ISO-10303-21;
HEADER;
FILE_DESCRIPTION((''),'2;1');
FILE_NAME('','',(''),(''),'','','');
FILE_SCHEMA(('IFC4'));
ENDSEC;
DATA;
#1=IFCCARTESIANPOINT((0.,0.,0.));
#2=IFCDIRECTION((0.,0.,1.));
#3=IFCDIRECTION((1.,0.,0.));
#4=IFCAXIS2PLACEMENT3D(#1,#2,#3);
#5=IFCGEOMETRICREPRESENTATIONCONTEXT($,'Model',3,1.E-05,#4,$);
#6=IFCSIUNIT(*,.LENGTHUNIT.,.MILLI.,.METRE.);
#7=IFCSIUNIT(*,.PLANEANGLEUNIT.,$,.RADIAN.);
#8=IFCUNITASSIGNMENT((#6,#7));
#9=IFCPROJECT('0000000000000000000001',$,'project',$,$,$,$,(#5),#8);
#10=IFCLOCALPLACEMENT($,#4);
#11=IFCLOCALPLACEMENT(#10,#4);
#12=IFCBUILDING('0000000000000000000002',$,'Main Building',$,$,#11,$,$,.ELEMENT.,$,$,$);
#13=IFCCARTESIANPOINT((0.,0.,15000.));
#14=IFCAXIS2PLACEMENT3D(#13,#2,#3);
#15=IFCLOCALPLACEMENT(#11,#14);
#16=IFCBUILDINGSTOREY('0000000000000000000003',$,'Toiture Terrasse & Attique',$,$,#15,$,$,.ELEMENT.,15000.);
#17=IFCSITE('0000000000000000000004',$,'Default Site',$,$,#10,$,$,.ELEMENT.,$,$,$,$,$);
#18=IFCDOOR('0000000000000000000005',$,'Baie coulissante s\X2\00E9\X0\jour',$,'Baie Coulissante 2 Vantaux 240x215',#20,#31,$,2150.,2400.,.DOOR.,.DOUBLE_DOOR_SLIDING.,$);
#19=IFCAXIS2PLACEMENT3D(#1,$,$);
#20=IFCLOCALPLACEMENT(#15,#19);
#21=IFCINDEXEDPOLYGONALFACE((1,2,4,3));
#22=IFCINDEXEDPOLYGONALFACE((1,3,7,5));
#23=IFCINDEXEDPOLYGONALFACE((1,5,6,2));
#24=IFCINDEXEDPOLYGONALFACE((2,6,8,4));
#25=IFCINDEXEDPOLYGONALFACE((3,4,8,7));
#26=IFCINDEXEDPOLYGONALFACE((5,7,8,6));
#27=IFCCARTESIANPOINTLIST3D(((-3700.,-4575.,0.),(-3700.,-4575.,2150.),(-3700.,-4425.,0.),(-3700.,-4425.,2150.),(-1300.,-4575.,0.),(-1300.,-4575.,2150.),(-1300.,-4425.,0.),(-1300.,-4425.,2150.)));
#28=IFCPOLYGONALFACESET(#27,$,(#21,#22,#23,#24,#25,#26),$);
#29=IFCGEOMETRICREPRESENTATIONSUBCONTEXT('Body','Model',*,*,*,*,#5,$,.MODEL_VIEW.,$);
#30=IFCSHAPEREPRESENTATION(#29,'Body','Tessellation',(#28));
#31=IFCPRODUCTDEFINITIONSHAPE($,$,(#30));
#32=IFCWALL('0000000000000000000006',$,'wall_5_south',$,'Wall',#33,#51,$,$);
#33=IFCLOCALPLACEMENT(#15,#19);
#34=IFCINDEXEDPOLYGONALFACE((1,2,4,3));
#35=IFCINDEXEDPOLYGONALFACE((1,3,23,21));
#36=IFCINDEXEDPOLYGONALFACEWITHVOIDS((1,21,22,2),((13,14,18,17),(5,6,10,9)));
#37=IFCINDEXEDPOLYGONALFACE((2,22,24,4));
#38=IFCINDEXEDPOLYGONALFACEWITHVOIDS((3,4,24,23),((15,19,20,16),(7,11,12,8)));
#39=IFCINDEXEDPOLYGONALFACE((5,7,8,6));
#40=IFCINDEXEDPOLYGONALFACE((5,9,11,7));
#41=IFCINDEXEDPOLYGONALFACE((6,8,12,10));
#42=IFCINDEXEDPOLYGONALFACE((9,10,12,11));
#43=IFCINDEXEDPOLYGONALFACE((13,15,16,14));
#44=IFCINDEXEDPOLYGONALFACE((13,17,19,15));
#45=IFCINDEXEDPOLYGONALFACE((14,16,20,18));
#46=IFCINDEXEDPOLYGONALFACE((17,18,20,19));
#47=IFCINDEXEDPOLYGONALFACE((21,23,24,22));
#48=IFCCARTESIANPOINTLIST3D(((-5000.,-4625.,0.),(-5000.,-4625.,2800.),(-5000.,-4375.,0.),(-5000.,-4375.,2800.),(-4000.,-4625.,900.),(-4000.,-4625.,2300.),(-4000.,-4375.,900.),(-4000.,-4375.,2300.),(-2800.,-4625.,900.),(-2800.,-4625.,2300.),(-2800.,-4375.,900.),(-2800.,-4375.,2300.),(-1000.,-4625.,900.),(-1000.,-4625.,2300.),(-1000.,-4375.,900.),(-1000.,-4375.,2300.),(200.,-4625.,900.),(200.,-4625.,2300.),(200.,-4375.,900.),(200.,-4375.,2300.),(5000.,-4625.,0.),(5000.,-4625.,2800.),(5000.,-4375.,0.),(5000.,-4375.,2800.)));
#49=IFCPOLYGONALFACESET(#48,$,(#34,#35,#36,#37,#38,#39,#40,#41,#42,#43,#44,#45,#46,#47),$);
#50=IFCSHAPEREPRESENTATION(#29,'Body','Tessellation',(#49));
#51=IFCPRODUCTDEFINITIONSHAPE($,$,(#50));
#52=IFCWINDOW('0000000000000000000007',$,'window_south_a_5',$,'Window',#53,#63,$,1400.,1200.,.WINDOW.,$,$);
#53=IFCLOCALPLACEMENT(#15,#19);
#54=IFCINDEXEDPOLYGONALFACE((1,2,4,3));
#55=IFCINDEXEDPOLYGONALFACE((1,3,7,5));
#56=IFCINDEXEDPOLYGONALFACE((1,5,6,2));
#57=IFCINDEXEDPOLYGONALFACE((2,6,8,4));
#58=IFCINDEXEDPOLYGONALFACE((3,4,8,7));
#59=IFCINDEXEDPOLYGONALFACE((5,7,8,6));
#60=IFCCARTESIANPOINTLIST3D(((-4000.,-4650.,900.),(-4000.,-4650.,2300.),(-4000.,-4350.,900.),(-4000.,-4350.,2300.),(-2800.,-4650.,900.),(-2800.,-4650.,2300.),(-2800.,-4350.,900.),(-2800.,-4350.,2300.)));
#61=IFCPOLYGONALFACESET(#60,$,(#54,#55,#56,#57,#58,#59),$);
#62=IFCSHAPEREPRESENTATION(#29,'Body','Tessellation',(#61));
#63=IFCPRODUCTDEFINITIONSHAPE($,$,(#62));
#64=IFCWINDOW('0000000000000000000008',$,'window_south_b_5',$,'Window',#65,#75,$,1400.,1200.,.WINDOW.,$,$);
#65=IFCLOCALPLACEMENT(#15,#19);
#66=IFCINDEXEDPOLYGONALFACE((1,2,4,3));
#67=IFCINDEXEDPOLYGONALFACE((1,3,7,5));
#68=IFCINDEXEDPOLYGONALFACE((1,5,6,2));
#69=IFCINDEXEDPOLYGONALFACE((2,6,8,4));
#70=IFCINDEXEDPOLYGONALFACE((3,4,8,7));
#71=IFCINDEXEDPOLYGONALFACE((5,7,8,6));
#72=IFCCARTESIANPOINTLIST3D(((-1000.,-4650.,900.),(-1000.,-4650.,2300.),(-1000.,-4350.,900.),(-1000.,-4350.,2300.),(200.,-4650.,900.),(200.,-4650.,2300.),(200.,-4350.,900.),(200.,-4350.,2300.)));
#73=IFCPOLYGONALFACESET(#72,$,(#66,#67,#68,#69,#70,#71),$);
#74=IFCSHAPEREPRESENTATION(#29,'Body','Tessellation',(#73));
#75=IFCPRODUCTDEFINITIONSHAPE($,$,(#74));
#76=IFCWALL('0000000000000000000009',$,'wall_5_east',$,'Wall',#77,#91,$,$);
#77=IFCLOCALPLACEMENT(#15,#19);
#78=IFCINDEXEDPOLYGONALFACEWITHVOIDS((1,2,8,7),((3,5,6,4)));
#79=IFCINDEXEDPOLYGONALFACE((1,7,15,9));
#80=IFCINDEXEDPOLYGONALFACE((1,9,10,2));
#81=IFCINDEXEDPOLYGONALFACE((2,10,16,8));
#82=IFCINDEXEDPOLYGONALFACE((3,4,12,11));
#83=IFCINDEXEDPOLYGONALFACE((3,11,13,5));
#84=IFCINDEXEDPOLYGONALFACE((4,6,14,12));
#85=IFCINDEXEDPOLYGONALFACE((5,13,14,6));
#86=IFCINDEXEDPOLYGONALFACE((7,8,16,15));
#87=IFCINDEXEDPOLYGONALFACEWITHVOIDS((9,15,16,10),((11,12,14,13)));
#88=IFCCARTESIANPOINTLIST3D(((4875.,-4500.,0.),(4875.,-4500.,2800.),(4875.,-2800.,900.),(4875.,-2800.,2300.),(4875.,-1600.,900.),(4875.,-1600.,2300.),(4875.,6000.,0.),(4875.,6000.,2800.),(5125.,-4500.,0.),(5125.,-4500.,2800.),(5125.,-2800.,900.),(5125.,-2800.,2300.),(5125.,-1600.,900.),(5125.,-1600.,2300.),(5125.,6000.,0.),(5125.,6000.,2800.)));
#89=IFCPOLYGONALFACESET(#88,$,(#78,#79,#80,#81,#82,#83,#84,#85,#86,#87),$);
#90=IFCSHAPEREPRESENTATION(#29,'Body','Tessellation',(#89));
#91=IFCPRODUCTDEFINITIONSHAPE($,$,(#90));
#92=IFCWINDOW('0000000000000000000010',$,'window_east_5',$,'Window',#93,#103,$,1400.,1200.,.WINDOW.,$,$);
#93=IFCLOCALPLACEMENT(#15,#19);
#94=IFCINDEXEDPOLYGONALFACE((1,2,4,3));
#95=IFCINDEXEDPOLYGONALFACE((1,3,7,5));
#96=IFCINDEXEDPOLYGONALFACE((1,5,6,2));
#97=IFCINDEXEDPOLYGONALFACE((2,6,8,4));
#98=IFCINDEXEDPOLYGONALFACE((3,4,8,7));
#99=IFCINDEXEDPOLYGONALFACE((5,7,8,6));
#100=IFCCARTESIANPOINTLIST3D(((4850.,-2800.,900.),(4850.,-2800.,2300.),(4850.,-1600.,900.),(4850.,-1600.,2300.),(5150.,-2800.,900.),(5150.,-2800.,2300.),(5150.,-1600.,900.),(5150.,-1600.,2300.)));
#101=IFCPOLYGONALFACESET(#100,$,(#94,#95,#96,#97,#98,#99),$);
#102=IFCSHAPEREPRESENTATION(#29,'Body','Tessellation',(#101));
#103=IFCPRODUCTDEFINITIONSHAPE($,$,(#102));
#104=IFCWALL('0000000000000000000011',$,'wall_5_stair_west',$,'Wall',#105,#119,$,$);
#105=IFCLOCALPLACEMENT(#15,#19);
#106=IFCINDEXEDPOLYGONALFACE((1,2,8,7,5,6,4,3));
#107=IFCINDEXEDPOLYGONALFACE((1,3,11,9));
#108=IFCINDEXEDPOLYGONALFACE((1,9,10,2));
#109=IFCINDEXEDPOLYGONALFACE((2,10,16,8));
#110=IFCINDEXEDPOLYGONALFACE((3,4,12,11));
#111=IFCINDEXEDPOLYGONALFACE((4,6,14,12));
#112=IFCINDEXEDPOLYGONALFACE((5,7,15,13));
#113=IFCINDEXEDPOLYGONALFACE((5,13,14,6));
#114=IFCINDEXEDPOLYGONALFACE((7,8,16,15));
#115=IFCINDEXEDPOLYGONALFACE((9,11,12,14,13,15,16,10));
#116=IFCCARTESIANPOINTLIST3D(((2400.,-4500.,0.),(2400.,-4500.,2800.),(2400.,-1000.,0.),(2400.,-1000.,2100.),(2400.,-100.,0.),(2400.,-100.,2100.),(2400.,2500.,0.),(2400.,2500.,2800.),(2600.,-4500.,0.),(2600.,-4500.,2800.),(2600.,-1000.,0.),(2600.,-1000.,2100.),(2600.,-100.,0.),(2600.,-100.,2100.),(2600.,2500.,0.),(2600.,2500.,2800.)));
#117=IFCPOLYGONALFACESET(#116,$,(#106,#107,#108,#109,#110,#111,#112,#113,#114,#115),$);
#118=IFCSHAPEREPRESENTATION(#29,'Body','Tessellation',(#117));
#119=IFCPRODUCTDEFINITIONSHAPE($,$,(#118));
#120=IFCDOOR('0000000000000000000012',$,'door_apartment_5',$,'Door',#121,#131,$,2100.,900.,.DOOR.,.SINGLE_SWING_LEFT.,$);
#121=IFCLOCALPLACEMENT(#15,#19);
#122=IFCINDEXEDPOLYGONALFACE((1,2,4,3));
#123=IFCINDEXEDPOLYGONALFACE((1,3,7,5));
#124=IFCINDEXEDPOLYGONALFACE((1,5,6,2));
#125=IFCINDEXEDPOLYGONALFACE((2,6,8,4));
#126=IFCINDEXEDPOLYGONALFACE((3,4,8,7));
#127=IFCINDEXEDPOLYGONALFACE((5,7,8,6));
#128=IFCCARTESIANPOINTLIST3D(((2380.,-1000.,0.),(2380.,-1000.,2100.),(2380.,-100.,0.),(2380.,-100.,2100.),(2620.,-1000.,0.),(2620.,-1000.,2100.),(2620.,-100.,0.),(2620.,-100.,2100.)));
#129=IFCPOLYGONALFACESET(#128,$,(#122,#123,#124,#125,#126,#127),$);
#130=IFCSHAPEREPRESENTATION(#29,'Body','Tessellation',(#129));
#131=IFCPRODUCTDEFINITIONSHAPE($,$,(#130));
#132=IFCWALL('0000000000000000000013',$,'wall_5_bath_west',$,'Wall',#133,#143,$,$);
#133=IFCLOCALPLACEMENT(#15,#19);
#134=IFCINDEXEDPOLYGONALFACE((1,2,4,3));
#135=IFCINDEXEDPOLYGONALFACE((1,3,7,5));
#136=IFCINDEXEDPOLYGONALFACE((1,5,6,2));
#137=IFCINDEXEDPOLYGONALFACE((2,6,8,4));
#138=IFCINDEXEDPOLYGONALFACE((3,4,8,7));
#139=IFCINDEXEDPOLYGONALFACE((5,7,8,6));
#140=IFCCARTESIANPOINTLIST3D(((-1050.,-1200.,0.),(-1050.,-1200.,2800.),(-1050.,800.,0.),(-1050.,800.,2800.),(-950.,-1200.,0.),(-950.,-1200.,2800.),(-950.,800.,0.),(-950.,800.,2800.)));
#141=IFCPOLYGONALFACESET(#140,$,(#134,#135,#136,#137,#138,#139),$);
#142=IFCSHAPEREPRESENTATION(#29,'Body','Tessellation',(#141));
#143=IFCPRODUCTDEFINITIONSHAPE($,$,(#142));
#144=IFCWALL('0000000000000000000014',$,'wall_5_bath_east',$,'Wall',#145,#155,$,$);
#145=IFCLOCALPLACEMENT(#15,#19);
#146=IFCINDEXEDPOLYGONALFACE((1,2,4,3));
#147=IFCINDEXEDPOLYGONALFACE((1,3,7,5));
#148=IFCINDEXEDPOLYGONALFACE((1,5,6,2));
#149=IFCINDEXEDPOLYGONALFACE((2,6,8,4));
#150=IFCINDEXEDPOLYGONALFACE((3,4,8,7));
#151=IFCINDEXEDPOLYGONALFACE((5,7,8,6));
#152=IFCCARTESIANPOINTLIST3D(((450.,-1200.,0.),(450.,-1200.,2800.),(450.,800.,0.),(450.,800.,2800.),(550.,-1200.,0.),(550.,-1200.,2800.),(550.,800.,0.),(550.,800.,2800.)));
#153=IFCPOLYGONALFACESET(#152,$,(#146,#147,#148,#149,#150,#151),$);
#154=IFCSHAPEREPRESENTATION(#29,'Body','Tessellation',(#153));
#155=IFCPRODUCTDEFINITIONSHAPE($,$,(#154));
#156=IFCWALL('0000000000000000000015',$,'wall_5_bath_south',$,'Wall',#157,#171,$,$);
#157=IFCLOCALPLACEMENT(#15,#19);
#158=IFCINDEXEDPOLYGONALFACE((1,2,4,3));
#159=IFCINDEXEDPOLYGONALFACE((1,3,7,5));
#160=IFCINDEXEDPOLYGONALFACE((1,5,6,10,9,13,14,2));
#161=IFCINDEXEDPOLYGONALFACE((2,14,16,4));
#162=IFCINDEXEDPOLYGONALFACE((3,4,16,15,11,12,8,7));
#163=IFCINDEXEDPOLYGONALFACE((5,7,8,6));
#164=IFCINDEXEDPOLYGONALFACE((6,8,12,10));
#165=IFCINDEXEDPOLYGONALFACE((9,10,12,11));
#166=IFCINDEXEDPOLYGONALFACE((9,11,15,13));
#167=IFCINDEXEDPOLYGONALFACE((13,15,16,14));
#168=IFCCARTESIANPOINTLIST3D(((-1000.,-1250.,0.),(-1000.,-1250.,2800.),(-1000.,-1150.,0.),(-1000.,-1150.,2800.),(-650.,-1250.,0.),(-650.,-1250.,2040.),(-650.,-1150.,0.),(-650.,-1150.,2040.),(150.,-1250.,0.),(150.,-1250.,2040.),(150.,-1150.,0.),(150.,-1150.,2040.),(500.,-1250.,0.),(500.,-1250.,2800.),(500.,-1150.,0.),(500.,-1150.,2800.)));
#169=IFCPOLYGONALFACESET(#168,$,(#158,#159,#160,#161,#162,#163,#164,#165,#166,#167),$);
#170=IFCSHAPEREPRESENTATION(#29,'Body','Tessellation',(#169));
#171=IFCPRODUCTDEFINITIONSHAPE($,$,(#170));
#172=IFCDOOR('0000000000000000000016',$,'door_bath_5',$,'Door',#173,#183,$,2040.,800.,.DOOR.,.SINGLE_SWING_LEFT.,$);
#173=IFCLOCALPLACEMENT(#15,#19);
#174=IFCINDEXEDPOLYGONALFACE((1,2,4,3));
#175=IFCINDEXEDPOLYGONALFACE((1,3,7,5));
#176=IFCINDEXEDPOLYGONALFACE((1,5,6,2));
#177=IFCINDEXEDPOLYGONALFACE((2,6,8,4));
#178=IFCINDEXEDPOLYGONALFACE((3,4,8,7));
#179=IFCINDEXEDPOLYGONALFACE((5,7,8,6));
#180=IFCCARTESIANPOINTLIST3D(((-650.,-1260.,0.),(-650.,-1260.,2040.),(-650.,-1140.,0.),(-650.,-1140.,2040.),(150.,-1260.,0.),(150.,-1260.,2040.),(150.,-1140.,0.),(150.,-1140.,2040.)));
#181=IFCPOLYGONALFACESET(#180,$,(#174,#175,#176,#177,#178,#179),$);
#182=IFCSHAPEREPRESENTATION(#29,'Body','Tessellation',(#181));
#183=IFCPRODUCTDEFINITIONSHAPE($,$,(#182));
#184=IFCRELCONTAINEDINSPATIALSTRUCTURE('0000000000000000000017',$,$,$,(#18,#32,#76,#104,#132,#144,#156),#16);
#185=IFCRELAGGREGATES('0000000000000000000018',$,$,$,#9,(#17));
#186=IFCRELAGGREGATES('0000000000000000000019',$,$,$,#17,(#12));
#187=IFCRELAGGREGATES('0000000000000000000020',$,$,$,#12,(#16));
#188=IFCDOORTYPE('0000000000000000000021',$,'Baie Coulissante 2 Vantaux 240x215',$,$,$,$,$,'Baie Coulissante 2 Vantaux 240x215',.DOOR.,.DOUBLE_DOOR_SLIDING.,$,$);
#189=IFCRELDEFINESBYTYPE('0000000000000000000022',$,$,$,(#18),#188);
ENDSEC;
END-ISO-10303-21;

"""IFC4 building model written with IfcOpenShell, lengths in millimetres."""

from ifc_helpers import new_model, si_unit, frame, origin_with_axes, place, context, subcontext, project, spatial, polyline, outline, extrude, type_object, element, fill, save


model = new_model("IFC4")

# Units and contexts
model_context = context("Model", 3, precision=1e-05, world=origin_with_axes())
body_context = subcontext(model_context, "Body", "Model", "MODEL_VIEW")
ifc_project = project(units=[si_unit("LENGTHUNIT", "METRE", prefix="MILLI"), si_unit("PLANEANGLEUNIT", "RADIAN")], contexts=[model_context])

# Site, building, storey
site_placement = place(None, origin_with_axes())
site = spatial("IfcSite", under=ifc_project, at=site_placement, Name="Default Site", CompositionType="ELEMENT")
building_placement = place(site_placement, origin_with_axes())
building = spatial("IfcBuilding", under=site, at=building_placement, Name="Main Building", CompositionType="ELEMENT")
storey_placement = place(building_placement, frame((0.0, 0.0, 15000.0), z_axis=(0.0, 0.0, 1.0), x_axis=(1.0, 0.0, 0.0)))
storey = spatial("IfcBuildingStorey", under=building, at=storey_placement, Name="Toiture Terrasse & Attique", CompositionType="ELEMENT", Elevation=15000.0)

# Door
door_type = type_object("IfcDoorType", Name="Baie Coulissante 2 Vantaux 240x215", ElementType="Baie Coulissante 2 Vantaux 240x215", OperationType="DOUBLE_DOOR_SLIDING", PredefinedType="DOOR")
door_1_placement = place(storey_placement, frame((-2500.0, -4500.0, 0.0), z_axis=(0.0, 0.0, 1.0), x_axis=(1.0, 0.0, 0.0)))
element("IfcDoor", 1, at=door_1_placement, inside=storey, type_object=door_type, Name="Baie coulissante séjour", ObjectType="Baie Coulissante 2 Vantaux 240x215", OperationType="DOUBLE_DOOR_SLIDING", OverallHeight=2150.0, OverallWidth=2400.0, PredefinedType="DOOR", context=body_context, shape_type="SweptSolid", body=[
    extrude(outline(polyline([(-1200.0, -75.0), (1200.0, -75.0), (1200.0, 75.0), (-1200.0, 75.0), (-1200.0, -75.0)])), origin_with_axes(), (0.0, 0.0, 1.0), 2150.0),
])

# Wall, openings, windows
wall_1_placement = place(storey_placement, frame((-5000.0, -4500.0, 0.0), z_axis=(0.0, 0.0, 1.0), x_axis=(1.0, 0.0, 0.0)))
wall_1 = element("IfcWall", 2, at=wall_1_placement, inside=storey, Name="wall_5_south", ObjectType="Wall", context=body_context, shape_type="SweptSolid", body=[
    extrude(outline(polyline([(0.0, -125.0), (10000.0, -125.0), (10000.0, 125.0), (0.0, 125.0), (0.0, -125.0)])), origin_with_axes(), (0.0, 0.0, 1.0), 2800.0),
])
placement_1 = place(wall_1_placement, frame((1000.0, 0.0, 900.0), z_axis=(0.0, 0.0, 1.0), x_axis=(1.0, 0.0, 0.0)))
opening_1 = element("IfcOpeningElement", 3, at=placement_1, cuts=wall_1, PredefinedType="OPENING", context=body_context, shape_type="SweptSolid", body=[
    extrude(outline(polyline([(0.0, -150.0), (1200.0, -150.0), (1200.0, 150.0), (0.0, 150.0), (0.0, -150.0)])), origin_with_axes(), (0.0, 0.0, 1.0), 1400.0),
])
placement_2 = place(wall_1_placement, frame((4000.0, 0.0, 900.0), z_axis=(0.0, 0.0, 1.0), x_axis=(1.0, 0.0, 0.0)))
opening_2 = element("IfcOpeningElement", 4, at=placement_2, cuts=wall_1, PredefinedType="OPENING", context=body_context, shape_type="SweptSolid", body=[
    extrude(outline(polyline([(0.0, -150.0), (1200.0, -150.0), (1200.0, 150.0), (0.0, 150.0), (0.0, -150.0)])), origin_with_axes(), (0.0, 0.0, 1.0), 1400.0),
])
window_1 = element("IfcWindow", 5, at=placement_1, Name="window_south_a_5", ObjectType="Window", OverallHeight=1400.0, OverallWidth=1200.0, PredefinedType="WINDOW", context=body_context, shape_type="SweptSolid", body=[
    extrude(outline(polyline([(0.0, -150.0), (1200.0, -150.0), (1200.0, 150.0), (0.0, 150.0), (0.0, -150.0)])), origin_with_axes(), (0.0, 0.0, 1.0), 1400.0),
])
fill(opening_1, window_1)
window_2 = element("IfcWindow", 6, at=placement_2, Name="window_south_b_5", ObjectType="Window", OverallHeight=1400.0, OverallWidth=1200.0, PredefinedType="WINDOW", context=body_context, shape_type="SweptSolid", body=[
    extrude(outline(polyline([(0.0, -150.0), (1200.0, -150.0), (1200.0, 150.0), (0.0, 150.0), (0.0, -150.0)])), origin_with_axes(), (0.0, 0.0, 1.0), 1400.0),
])
fill(opening_2, window_2)

# Wall, opening, window
wall_2_placement = place(storey_placement, frame((5000.0, -4500.0, 0.0), z_axis=(0.0, 0.0, 1.0), x_axis=(0.0, 1.0, 0.0)))
wall_2 = element("IfcWall", 7, at=wall_2_placement, inside=storey, Name="wall_5_east", ObjectType="Wall", context=body_context, shape_type="SweptSolid", body=[
    extrude(outline(polyline([(0.0, -125.0), (10500.0, -125.0), (10500.0, 125.0), (0.0, 125.0), (0.0, -125.0)])), origin_with_axes(), (0.0, 0.0, 1.0), 2800.0),
])
placement_3 = place(wall_2_placement, frame((1700.0, 0.0, 900.0), z_axis=(0.0, 0.0, 1.0), x_axis=(1.0, 0.0, 0.0)))
opening_3 = element("IfcOpeningElement", 8, at=placement_3, cuts=wall_2, PredefinedType="OPENING", context=body_context, shape_type="SweptSolid", body=[
    extrude(outline(polyline([(0.0, -150.0), (1200.0, -150.0), (1200.0, 150.0), (0.0, 150.0), (0.0, -150.0)])), origin_with_axes(), (0.0, 0.0, 1.0), 1400.0),
])
window_3 = element("IfcWindow", 9, at=placement_3, Name="window_east_5", ObjectType="Window", OverallHeight=1400.0, OverallWidth=1200.0, PredefinedType="WINDOW", context=body_context, shape_type="SweptSolid", body=[
    extrude(outline(polyline([(0.0, -150.0), (1200.0, -150.0), (1200.0, 150.0), (0.0, 150.0), (0.0, -150.0)])), origin_with_axes(), (0.0, 0.0, 1.0), 1400.0),
])
fill(opening_3, window_3)

# Wall, opening, door
wall_3_placement = place(storey_placement, frame((2500.0, -4500.0, 0.0), z_axis=(0.0, 0.0, 1.0), x_axis=(0.0, 1.0, 0.0)))
wall_3 = element("IfcWall", 10, at=wall_3_placement, inside=storey, Name="wall_5_stair_west", ObjectType="Wall", context=body_context, shape_type="SweptSolid", body=[
    extrude(outline(polyline([(0.0, -100.0), (7000.0, -100.0), (7000.0, 100.0), (0.0, 100.0), (0.0, -100.0)])), origin_with_axes(), (0.0, 0.0, 1.0), 2800.0),
])
placement_4 = place(wall_3_placement, frame((3500.0, 0.0, 0.0), z_axis=(0.0, 0.0, 1.0), x_axis=(1.0, 0.0, 0.0)))
opening_4 = element("IfcOpeningElement", 11, at=placement_4, cuts=wall_3, PredefinedType="OPENING", context=body_context, shape_type="SweptSolid", body=[
    extrude(outline(polyline([(0.0, -120.0), (900.0, -120.0), (900.0, 120.0), (0.0, 120.0), (0.0, -120.0)])), origin_with_axes(), (0.0, 0.0, 1.0), 2100.0),
])
door_2 = element("IfcDoor", 12, at=placement_4, Name="door_apartment_5", ObjectType="Door", OperationType="SINGLE_SWING_LEFT", OverallHeight=2100.0, OverallWidth=900.0, PredefinedType="DOOR", context=body_context, shape_type="SweptSolid", body=[
    extrude(outline(polyline([(0.0, -120.0), (900.0, -120.0), (900.0, 120.0), (0.0, 120.0), (0.0, -120.0)])), origin_with_axes(), (0.0, 0.0, 1.0), 2100.0),
])
fill(opening_4, door_2)

# Walls
for number, where, z_axis, x_axis, name in (
    (13, (-1000.0, -1200.0, 0.0), (0.0, 0.0, 1.0), (0.0, 1.0, 0.0), "wall_5_bath_west"),
    (14, (500.0, -1200.0, 0.0), (0.0, 0.0, 1.0), (0.0, 1.0, 0.0), "wall_5_bath_east"),
):
    element("IfcWall", number, at=place(storey_placement, frame(where, z_axis=z_axis, x_axis=x_axis)), inside=storey, Name=name, ObjectType="Wall", context=body_context, shape_type="SweptSolid", body=[
        extrude(outline(polyline([(0.0, -50.0), (2000.0, -50.0), (2000.0, 50.0), (0.0, 50.0), (0.0, -50.0)])), origin_with_axes(), (0.0, 0.0, 1.0), 2800.0),
    ])

# Wall, opening, door
wall_4_placement = place(storey_placement, frame((-1000.0, -1200.0, 0.0), z_axis=(0.0, 0.0, 1.0), x_axis=(1.0, 0.0, 0.0)))
wall_4 = element("IfcWall", 15, at=wall_4_placement, inside=storey, Name="wall_5_bath_south", ObjectType="Wall", context=body_context, shape_type="SweptSolid", body=[
    extrude(outline(polyline([(0.0, -50.0), (1500.0, -50.0), (1500.0, 50.0), (0.0, 50.0), (0.0, -50.0)])), origin_with_axes(), (0.0, 0.0, 1.0), 2800.0),
])
placement_5 = place(wall_4_placement, frame((350.0, 0.0, 0.0), z_axis=(0.0, 0.0, 1.0), x_axis=(1.0, 0.0, 0.0)))
opening_5 = element("IfcOpeningElement", 16, at=placement_5, cuts=wall_4, PredefinedType="OPENING", context=body_context, shape_type="SweptSolid", body=[
    extrude(outline(polyline([(0.0, -60.0), (800.0, -60.0), (800.0, 60.0), (0.0, 60.0), (0.0, -60.0)])), origin_with_axes(), (0.0, 0.0, 1.0), 2040.0),
])
door_3 = element("IfcDoor", 17, at=placement_5, Name="door_bath_5", ObjectType="Door", OperationType="SINGLE_SWING_LEFT", OverallHeight=2040.0, OverallWidth=800.0, PredefinedType="DOOR", context=body_context, shape_type="SweptSolid", body=[
    extrude(outline(polyline([(0.0, -60.0), (800.0, -60.0), (800.0, 60.0), (0.0, 60.0), (0.0, -60.0)])), origin_with_axes(), (0.0, 0.0, 1.0), 2040.0),
])
fill(opening_5, door_3)

save(model, "model.ifc")
